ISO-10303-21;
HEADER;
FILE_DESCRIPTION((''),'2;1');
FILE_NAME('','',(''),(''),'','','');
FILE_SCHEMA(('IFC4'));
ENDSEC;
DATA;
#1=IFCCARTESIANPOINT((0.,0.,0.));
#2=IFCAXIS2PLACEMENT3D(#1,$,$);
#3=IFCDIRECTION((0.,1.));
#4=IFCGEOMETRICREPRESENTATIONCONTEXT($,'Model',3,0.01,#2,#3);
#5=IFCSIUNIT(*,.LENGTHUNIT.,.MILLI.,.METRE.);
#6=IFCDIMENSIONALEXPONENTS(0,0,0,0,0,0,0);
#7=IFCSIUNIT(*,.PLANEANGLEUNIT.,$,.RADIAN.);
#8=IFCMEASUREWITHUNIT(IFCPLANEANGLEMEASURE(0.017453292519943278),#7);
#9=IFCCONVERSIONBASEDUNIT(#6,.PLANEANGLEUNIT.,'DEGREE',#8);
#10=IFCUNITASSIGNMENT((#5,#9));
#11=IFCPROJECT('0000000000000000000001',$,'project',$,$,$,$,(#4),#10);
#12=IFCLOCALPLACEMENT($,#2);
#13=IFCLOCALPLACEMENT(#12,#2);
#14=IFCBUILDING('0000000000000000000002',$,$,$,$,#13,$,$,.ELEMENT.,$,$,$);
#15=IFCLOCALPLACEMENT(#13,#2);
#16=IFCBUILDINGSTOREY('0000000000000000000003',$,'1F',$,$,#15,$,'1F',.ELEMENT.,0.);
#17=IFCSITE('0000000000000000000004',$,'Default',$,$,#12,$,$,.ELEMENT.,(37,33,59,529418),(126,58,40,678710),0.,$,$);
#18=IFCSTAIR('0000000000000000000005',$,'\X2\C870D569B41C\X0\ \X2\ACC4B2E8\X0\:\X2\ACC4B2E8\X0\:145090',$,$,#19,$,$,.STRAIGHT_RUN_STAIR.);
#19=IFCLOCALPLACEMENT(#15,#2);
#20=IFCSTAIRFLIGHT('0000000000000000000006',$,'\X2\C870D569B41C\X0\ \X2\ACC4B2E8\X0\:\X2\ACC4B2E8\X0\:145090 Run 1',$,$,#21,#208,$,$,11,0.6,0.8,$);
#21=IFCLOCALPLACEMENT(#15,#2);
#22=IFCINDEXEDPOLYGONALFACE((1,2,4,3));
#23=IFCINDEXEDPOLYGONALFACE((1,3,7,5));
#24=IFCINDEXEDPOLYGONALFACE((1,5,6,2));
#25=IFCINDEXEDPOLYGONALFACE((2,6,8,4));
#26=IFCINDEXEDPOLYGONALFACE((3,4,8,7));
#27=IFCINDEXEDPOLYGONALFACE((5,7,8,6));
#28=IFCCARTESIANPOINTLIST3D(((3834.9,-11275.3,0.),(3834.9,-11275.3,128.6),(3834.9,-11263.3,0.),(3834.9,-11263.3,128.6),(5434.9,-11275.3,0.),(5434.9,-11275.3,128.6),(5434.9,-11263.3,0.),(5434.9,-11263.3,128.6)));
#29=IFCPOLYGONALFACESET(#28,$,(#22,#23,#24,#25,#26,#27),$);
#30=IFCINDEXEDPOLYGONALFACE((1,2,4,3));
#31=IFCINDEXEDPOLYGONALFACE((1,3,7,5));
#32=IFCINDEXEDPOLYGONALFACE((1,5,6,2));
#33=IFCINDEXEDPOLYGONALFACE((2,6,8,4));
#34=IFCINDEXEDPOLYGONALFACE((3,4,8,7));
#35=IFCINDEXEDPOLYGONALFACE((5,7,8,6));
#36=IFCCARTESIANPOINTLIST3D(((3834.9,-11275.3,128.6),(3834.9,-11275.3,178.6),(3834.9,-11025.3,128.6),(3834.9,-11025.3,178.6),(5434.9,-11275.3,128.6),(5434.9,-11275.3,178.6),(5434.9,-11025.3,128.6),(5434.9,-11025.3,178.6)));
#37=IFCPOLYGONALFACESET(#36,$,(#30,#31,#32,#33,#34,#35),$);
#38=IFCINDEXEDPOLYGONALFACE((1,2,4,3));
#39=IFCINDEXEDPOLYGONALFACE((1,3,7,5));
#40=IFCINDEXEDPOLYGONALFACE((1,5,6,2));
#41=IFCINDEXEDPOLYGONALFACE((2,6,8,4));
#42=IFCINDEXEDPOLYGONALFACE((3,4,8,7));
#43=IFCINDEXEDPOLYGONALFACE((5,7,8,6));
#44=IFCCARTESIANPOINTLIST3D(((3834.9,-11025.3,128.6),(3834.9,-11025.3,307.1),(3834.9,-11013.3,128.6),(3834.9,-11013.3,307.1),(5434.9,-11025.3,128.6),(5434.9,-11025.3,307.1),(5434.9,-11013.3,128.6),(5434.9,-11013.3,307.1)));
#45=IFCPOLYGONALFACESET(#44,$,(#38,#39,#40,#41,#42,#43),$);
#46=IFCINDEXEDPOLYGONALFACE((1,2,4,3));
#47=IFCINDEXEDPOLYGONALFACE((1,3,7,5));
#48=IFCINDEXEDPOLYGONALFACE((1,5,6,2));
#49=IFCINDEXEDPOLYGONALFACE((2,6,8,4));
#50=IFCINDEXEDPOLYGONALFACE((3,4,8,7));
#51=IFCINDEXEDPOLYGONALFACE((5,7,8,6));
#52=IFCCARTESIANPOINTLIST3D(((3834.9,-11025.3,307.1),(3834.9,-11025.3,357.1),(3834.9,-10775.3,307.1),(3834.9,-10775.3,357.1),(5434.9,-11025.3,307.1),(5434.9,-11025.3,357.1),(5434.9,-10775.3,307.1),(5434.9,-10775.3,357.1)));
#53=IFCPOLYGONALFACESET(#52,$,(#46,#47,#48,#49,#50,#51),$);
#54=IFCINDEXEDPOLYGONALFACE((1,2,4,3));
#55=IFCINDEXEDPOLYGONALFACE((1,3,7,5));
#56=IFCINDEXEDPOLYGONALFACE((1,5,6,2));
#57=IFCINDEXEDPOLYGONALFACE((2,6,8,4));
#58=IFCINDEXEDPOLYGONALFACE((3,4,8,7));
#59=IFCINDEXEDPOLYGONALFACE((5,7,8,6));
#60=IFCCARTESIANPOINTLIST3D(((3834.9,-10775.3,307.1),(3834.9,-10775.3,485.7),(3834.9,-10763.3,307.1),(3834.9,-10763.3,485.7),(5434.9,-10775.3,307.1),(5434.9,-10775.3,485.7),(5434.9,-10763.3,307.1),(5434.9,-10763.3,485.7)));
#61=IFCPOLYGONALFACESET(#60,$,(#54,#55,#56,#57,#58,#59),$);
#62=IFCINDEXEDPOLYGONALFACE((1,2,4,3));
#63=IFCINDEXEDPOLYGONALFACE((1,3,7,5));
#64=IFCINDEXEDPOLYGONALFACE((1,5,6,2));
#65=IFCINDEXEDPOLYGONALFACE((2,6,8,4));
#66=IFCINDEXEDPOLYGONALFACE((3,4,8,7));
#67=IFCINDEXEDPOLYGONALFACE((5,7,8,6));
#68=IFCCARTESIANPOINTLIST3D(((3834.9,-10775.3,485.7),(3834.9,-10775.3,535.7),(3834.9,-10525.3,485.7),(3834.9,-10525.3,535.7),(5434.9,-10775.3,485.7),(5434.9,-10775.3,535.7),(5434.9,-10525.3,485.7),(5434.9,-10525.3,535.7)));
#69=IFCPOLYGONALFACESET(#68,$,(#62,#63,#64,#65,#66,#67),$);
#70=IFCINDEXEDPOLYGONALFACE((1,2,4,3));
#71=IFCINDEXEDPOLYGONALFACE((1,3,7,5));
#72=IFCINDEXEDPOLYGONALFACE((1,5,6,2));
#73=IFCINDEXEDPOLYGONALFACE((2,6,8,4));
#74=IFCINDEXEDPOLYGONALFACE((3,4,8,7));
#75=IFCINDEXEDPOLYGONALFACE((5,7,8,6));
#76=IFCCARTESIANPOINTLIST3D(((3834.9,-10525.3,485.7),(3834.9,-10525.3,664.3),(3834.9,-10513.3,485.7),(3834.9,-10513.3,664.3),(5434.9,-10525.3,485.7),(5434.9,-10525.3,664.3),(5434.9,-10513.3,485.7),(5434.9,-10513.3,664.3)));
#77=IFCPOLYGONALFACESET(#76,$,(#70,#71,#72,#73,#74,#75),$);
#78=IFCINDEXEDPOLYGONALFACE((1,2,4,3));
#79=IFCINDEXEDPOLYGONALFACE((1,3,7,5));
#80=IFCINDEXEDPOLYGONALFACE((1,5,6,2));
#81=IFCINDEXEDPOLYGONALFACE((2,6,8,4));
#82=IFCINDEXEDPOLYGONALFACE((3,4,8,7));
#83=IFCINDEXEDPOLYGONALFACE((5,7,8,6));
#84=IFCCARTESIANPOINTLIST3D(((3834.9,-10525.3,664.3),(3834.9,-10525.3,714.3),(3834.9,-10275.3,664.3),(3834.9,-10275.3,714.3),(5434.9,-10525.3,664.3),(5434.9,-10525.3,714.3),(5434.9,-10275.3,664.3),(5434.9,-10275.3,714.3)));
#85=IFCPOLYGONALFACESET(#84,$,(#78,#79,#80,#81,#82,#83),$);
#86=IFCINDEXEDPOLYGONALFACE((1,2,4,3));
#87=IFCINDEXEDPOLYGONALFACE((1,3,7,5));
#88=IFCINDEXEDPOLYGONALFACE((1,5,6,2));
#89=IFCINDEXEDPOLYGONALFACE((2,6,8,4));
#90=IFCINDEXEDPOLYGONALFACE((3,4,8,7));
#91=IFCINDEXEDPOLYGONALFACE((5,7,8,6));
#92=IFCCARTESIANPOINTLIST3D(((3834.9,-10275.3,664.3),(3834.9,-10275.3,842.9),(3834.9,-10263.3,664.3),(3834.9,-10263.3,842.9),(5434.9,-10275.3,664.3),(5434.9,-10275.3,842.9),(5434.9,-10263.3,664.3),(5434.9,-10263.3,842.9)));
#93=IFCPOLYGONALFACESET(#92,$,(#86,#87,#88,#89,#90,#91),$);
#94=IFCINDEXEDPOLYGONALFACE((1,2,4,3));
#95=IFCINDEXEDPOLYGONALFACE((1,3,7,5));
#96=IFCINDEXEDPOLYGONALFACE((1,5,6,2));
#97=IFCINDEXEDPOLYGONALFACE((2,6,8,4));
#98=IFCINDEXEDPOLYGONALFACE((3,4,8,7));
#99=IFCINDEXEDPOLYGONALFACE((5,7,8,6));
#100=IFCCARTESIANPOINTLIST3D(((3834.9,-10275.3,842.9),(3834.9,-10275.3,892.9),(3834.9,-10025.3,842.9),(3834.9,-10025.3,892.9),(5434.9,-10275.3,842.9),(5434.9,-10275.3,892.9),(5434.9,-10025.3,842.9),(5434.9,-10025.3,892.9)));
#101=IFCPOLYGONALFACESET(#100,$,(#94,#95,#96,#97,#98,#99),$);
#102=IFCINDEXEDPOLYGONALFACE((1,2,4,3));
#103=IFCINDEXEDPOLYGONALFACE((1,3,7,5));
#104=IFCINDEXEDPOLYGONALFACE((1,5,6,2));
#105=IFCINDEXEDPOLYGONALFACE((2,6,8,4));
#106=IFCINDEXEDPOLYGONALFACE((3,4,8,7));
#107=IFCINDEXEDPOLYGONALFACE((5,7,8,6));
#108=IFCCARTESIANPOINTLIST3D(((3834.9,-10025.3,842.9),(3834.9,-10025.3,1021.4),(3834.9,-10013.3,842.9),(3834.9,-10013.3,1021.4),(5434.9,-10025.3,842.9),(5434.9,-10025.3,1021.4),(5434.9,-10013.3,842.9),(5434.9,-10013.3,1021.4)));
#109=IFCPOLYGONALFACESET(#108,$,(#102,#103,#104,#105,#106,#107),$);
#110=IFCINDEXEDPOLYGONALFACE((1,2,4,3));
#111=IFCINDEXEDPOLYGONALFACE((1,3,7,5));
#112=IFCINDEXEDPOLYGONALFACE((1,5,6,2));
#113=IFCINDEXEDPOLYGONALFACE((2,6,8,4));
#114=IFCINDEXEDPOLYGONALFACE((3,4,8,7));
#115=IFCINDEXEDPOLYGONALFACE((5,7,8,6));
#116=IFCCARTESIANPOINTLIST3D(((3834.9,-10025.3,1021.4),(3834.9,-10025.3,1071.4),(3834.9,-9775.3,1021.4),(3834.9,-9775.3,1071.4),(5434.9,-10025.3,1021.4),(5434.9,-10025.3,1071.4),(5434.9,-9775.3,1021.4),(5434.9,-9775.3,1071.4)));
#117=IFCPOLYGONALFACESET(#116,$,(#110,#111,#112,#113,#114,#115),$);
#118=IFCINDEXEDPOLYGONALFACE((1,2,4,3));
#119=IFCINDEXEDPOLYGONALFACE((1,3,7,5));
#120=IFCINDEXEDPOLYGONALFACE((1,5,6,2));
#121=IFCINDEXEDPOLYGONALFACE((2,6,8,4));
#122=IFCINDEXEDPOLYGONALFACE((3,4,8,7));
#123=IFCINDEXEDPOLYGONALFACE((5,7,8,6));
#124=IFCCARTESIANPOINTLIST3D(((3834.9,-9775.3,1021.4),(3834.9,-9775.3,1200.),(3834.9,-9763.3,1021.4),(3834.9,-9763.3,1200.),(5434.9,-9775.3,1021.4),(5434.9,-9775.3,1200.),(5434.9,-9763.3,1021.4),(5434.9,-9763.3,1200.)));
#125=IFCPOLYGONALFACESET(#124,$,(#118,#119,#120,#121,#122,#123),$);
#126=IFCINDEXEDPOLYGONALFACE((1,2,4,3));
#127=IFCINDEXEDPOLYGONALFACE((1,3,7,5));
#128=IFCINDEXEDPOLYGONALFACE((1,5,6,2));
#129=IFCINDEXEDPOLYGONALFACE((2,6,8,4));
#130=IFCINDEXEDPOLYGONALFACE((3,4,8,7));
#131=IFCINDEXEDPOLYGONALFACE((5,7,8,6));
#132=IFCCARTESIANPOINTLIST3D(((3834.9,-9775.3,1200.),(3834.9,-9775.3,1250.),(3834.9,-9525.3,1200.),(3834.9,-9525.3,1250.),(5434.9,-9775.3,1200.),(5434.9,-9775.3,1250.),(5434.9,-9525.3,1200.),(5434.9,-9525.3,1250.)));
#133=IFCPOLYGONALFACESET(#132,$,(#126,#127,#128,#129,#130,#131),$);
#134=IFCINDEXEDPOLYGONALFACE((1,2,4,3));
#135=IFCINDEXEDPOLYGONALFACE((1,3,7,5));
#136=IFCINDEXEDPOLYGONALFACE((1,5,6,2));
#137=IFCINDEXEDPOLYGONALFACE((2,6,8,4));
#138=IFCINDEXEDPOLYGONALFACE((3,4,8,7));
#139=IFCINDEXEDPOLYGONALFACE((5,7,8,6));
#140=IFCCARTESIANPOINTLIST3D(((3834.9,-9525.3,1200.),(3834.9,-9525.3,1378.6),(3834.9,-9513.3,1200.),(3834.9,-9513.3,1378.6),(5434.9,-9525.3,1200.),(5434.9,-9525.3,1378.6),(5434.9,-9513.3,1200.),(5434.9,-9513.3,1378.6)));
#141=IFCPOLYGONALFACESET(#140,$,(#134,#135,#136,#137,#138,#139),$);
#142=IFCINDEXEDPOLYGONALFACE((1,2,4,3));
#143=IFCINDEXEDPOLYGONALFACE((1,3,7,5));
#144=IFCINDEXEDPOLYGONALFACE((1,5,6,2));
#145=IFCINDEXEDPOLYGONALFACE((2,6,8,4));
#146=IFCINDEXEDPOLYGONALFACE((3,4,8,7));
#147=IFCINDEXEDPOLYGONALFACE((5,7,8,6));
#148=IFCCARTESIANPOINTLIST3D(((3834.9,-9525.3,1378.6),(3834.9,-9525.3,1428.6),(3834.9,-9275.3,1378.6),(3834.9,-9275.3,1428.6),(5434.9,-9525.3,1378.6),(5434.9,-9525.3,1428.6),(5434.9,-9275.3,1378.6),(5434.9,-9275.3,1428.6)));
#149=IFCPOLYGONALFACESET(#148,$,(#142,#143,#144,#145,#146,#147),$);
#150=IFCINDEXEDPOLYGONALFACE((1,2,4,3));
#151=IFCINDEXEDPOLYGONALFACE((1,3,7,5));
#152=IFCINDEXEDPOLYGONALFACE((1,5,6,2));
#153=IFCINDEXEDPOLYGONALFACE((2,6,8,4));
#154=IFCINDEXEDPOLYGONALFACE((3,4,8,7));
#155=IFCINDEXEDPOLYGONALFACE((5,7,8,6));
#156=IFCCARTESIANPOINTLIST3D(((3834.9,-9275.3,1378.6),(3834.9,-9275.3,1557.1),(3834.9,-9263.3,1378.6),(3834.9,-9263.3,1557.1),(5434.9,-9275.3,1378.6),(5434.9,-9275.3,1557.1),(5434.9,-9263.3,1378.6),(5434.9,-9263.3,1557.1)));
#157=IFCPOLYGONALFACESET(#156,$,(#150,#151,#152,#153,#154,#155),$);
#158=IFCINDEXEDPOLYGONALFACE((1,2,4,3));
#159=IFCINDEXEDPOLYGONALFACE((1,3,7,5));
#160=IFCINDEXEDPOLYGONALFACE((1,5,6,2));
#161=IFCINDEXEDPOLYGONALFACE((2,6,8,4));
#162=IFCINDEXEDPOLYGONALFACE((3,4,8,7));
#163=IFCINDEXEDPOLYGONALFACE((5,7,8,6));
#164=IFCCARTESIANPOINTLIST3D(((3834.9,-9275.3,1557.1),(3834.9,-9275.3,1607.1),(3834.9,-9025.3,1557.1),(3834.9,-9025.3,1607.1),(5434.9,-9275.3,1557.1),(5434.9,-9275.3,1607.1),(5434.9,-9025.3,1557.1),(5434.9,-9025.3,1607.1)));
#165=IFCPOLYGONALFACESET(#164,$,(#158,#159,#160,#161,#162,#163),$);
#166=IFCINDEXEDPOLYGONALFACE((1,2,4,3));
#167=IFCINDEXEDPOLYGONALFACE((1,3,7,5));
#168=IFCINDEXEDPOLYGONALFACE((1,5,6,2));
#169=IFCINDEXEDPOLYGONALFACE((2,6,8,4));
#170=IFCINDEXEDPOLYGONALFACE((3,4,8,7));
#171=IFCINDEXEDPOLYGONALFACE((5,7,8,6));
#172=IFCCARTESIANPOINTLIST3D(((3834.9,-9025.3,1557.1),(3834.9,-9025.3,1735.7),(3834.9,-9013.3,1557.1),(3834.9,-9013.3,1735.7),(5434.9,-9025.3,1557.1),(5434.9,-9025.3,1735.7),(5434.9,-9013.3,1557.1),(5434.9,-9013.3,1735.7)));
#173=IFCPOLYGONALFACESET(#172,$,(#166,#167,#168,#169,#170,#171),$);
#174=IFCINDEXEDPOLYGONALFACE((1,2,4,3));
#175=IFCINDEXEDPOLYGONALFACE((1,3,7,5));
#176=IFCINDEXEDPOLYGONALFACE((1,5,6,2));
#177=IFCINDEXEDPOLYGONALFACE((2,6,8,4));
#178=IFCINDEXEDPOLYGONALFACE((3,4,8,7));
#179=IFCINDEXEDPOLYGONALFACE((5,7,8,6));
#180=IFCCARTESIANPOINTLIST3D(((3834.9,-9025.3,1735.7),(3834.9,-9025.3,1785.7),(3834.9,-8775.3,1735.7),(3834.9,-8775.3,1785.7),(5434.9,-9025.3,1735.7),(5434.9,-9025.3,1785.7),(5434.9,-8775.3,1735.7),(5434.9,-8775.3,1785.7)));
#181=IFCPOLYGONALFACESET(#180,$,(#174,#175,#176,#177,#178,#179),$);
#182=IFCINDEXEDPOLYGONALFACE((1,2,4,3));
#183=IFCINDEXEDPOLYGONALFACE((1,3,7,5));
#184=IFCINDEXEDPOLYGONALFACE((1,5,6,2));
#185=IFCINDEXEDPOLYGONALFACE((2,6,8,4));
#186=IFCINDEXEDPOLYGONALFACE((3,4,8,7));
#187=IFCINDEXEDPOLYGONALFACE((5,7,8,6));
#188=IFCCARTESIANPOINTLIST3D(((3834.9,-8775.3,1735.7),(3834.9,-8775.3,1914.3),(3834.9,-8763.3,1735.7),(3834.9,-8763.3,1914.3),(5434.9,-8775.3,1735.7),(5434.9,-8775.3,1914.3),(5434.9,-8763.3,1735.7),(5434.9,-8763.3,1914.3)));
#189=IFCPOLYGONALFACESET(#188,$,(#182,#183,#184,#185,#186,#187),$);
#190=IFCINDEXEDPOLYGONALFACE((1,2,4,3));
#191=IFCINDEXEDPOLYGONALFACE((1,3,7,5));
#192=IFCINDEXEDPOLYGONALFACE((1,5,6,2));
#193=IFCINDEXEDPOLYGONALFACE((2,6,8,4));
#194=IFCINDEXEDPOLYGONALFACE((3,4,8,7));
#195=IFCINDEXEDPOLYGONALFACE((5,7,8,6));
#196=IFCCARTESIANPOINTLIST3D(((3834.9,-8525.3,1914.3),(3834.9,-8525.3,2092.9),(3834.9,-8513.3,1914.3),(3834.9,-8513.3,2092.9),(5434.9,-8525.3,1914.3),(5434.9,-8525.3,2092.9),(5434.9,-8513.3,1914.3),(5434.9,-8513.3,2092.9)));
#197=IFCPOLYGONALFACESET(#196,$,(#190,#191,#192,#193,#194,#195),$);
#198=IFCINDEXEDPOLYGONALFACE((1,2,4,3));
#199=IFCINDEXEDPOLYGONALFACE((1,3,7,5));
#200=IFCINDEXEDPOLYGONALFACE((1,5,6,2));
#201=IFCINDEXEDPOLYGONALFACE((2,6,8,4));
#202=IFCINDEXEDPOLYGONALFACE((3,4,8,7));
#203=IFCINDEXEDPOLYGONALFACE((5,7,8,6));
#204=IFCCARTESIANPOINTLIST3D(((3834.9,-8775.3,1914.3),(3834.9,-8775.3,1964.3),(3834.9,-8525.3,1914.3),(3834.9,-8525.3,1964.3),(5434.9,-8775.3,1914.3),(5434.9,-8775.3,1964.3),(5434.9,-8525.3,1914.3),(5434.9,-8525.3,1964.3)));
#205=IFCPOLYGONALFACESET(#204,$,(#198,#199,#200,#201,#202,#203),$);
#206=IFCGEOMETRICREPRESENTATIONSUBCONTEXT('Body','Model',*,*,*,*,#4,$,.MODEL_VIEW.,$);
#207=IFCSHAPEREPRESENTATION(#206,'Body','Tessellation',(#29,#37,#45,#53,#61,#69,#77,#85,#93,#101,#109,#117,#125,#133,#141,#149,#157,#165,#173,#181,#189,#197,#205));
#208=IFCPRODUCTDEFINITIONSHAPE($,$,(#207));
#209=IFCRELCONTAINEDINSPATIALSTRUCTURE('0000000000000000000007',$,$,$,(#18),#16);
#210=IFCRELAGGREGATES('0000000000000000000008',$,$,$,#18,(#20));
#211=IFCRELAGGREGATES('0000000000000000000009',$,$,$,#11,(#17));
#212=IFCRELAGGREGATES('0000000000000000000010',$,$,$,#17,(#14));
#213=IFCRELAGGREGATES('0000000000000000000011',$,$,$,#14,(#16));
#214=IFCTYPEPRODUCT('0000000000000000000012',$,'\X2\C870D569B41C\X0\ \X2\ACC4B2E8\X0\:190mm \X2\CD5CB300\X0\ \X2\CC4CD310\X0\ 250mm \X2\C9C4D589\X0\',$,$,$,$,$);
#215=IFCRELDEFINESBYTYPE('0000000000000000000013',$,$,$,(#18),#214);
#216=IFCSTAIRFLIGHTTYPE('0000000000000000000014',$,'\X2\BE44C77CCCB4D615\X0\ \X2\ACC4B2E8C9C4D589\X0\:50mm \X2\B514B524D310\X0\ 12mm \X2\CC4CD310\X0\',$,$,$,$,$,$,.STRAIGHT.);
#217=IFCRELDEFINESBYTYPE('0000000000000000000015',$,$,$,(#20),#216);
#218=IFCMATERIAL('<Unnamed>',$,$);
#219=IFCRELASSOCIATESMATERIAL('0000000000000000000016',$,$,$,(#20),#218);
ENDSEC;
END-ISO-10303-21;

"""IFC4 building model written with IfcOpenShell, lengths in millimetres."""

from ifc_helpers import new_model, entity, si_unit, converted_unit, direction, frame, frame_2d, origin, origin_2d_with_axis, place, context, subcontext, project, spatial, rectangle, extrude, material, type_object, element, aggregate, save


model = new_model("IFC4")

# Units and contexts
model_context = context("Model", 3, precision=0.01, world=origin(), true_north=direction((0.0, 1.0)))
body_context = subcontext(model_context, "Body", "Model", "MODEL_VIEW")
ifc_project = project(units=[si_unit("LENGTHUNIT", "METRE", prefix="MILLI"), converted_unit("PLANEANGLEUNIT", "DEGREE", entity("IfcPlaneAngleMeasure", 0.017453292519943278), si_unit("PLANEANGLEUNIT", "RADIAN"), dimensions=[0, 0, 0, 0, 0, 0, 0])], contexts=[model_context])

# Site, building, storey
site_placement = place(None, origin())
site = spatial("IfcSite", under=ifc_project, at=site_placement, Name="Default", CompositionType="ELEMENT", RefLatitude=(37, 33, 59, 529418), RefLongitude=(126, 58, 40, 678710), RefElevation=0.0)
building_placement = place(site_placement, origin())
building = spatial("IfcBuilding", under=site, at=building_placement, CompositionType="ELEMENT")
storey_placement = place(building_placement, origin())
storey = spatial("IfcBuildingStorey", under=building, at=storey_placement, Name="1F", LongName="1F", CompositionType="ELEMENT", Elevation=0.0)

# Stair
type_product = type_object("IfcTypeProduct", Name="조합된 계단:190mm 최대 챌판 250mm 진행")
stair_placement = place(storey_placement, origin())
stair = element("IfcStair", 1, at=stair_placement, inside=storey, type_object=type_product, Name="조합된 계단:계단:145090", PredefinedType="STRAIGHT_RUN_STAIR")
ifc_material_1 = material(Name="<Unnamed>")

# Stair flight
stair_flight_type = type_object("IfcStairFlightType", Name="비일체형 계단진행:50mm 디딤판 12mm 챌판", PredefinedType="STRAIGHT")
stair_flight_placement = place(stair_placement, origin())
stair_flight = element("IfcStairFlight", 2, at=stair_flight_placement, type_object=stair_flight_type, material=ifc_material_1, Name="조합된 계단:계단:145090 Run 1", NumberOfTreads=11, RiserHeight=0.6, TreadLength=0.8, context=body_context, shape_type="SweptSolid", body=[
    extrude(rectangle(XDim=1600.0, YDim=12.0, at=frame_2d((0.0, 0.0), x_axis=(1.0, 0.0))), frame((4634.9, -11269.3, 0.0), z_axis=(0.0, 0.0, 1.0), x_axis=(-1.0, 0.0, 0.0)), (0.0, 0.0, 1.0), 128.6),
    extrude(rectangle(XDim=250.0, YDim=1600.0, at=frame_2d((0.0, 0.0), x_axis=(1.0, 0.0))), frame((4634.9, -11150.3, 128.6), z_axis=(0.0, 0.0, 1.0), x_axis=(0.0, -1.0, 0.0)), (0.0, 0.0, 1.0), 50.0),
    extrude(rectangle(XDim=1600.0, YDim=12.0, at=frame_2d((0.0, 0.0), x_axis=(1.0, 0.0))), frame((4634.9, -11019.3, 128.6), z_axis=(0.0, 0.0, 1.0), x_axis=(-1.0, 0.0, 0.0)), (0.0, 0.0, 1.0), 178.6),
    extrude(rectangle(XDim=250.0, YDim=1600.0, at=frame_2d((0.0, 0.0), x_axis=(1.0, 0.0))), frame((4634.9, -10900.3, 307.1), z_axis=(0.0, 0.0, 1.0), x_axis=(0.0, -1.0, 0.0)), (0.0, 0.0, 1.0), 50.0),
    extrude(rectangle(XDim=1600.0, YDim=12.0, at=frame_2d((0.0, 0.0), x_axis=(1.0, 0.0))), frame((4634.9, -10769.3, 307.1), z_axis=(0.0, 0.0, 1.0), x_axis=(-1.0, 0.0, 0.0)), (0.0, 0.0, 1.0), 178.6),
    extrude(rectangle(XDim=250.0, YDim=1600.0, at=origin_2d_with_axis()), frame((4634.9, -10650.3, 485.7), z_axis=(0.0, 0.0, 1.0), x_axis=(0.0, -1.0, 0.0)), (0.0, 0.0, 1.0), 50.0),
    extrude(rectangle(XDim=1600.0, YDim=12.0, at=frame_2d((0.0, 0.0), x_axis=(1.0, 0.0))), frame((4634.9, -10519.3, 485.7), z_axis=(0.0, 0.0, 1.0), x_axis=(-1.0, 0.0, 0.0)), (0.0, 0.0, 1.0), 178.6),
    extrude(rectangle(XDim=250.0, YDim=1600.0, at=frame_2d((0.0, 0.0), x_axis=(1.0, 0.0))), frame((4634.9, -10400.3, 664.3), z_axis=(0.0, 0.0, 1.0), x_axis=(0.0, -1.0, 0.0)), (0.0, 0.0, 1.0), 50.0),
    extrude(rectangle(XDim=1600.0, YDim=12.0, at=frame_2d((0.0, 0.0), x_axis=(1.0, 0.0))), frame((4634.9, -10269.3, 664.3), z_axis=(0.0, 0.0, 1.0), x_axis=(-1.0, 0.0, 0.0)), (0.0, 0.0, 1.0), 178.6),
    extrude(rectangle(XDim=250.0, YDim=1600.0, at=origin_2d_with_axis()), frame((4634.9, -10150.3, 842.9), z_axis=(0.0, 0.0, 1.0), x_axis=(0.0, -1.0, 0.0)), (0.0, 0.0, 1.0), 50.0),
    extrude(rectangle(XDim=1600.0, YDim=12.0, at=frame_2d((0.0, 0.0), x_axis=(1.0, 0.0))), frame((4634.9, -10019.3, 842.9), z_axis=(0.0, 0.0, 1.0), x_axis=(-1.0, 0.0, 0.0)), (0.0, 0.0, 1.0), 178.6),
    extrude(rectangle(XDim=250.0, YDim=1600.0, at=origin_2d_with_axis()), frame((4634.9, -9900.3, 1021.4), z_axis=(0.0, 0.0, 1.0), x_axis=(0.0, -1.0, 0.0)), (0.0, 0.0, 1.0), 50.0),
    extrude(rectangle(XDim=1600.0, YDim=12.0, at=frame_2d((0.0, 0.0), x_axis=(1.0, 0.0))), frame((4634.9, -9769.3, 1021.4), z_axis=(0.0, 0.0, 1.0), x_axis=(-1.0, 0.0, 0.0)), (0.0, 0.0, 1.0), 178.6),
    extrude(rectangle(XDim=250.0, YDim=1600.0, at=frame_2d((0.0, 0.0), x_axis=(1.0, 0.0))), frame((4634.9, -9650.3, 1200.0), z_axis=(0.0, 0.0, 1.0), x_axis=(0.0, -1.0, 0.0)), (0.0, 0.0, 1.0), 50.0),
    extrude(rectangle(XDim=1600.0, YDim=12.0, at=frame_2d((0.0, 0.0), x_axis=(1.0, 0.0))), frame((4634.9, -9519.3, 1200.0), z_axis=(0.0, 0.0, 1.0), x_axis=(-1.0, 0.0, 0.0)), (0.0, 0.0, 1.0), 178.6),
    extrude(rectangle(XDim=250.0, YDim=1600.0, at=origin_2d_with_axis()), frame((4634.9, -9400.3, 1378.6), z_axis=(0.0, 0.0, 1.0), x_axis=(0.0, -1.0, 0.0)), (0.0, 0.0, 1.0), 50.0),
    extrude(rectangle(XDim=1600.0, YDim=12.0, at=frame_2d((0.0, 0.0), x_axis=(1.0, 0.0))), frame((4634.9, -9269.3, 1378.6), z_axis=(0.0, 0.0, 1.0), x_axis=(-1.0, 0.0, 0.0)), (0.0, 0.0, 1.0), 178.6),
    extrude(rectangle(XDim=250.0, YDim=1600.0, at=frame_2d((0.0, 0.0), x_axis=(1.0, 0.0))), frame((4634.9, -9150.3, 1557.1), z_axis=(0.0, 0.0, 1.0), x_axis=(0.0, -1.0, 0.0)), (0.0, 0.0, 1.0), 50.0),
    extrude(rectangle(XDim=1600.0, YDim=12.0, at=frame_2d((0.0, 0.0), x_axis=(1.0, 0.0))), frame((4634.9, -9019.3, 1557.1), z_axis=(0.0, 0.0, 1.0), x_axis=(-1.0, 0.0, 0.0)), (0.0, 0.0, 1.0), 178.6),
    extrude(rectangle(XDim=250.0, YDim=1600.0, at=frame_2d((0.0, 0.0), x_axis=(1.0, 0.0))), frame((4634.9, -8900.3, 1735.7), z_axis=(0.0, 0.0, 1.0), x_axis=(0.0, -1.0, 0.0)), (0.0, 0.0, 1.0), 50.0),
    extrude(rectangle(XDim=1600.0, YDim=12.0, at=frame_2d((0.0, 0.0), x_axis=(1.0, 0.0))), frame((4634.9, -8769.3, 1735.7), z_axis=(0.0, 0.0, 1.0), x_axis=(-1.0, 0.0, 0.0)), (0.0, 0.0, 1.0), 178.6),
    extrude(rectangle(XDim=1600.0, YDim=12.0, at=frame_2d((0.0, 0.0), x_axis=(1.0, 0.0))), frame((4634.9, -8519.3, 1914.3), z_axis=(0.0, 0.0, 1.0), x_axis=(-1.0, 0.0, 0.0)), (0.0, 0.0, 1.0), 178.6),
    extrude(rectangle(XDim=250.0, YDim=1600.0, at=origin_2d_with_axis()), frame((4634.9, -8650.3, 1914.3), z_axis=(0.0, 0.0, 1.0), x_axis=(0.0, -1.0, 0.0)), (0.0, 0.0, 1.0), 50.0),
])
aggregate(stair, [stair_flight])

save(model, "model.ifc")
